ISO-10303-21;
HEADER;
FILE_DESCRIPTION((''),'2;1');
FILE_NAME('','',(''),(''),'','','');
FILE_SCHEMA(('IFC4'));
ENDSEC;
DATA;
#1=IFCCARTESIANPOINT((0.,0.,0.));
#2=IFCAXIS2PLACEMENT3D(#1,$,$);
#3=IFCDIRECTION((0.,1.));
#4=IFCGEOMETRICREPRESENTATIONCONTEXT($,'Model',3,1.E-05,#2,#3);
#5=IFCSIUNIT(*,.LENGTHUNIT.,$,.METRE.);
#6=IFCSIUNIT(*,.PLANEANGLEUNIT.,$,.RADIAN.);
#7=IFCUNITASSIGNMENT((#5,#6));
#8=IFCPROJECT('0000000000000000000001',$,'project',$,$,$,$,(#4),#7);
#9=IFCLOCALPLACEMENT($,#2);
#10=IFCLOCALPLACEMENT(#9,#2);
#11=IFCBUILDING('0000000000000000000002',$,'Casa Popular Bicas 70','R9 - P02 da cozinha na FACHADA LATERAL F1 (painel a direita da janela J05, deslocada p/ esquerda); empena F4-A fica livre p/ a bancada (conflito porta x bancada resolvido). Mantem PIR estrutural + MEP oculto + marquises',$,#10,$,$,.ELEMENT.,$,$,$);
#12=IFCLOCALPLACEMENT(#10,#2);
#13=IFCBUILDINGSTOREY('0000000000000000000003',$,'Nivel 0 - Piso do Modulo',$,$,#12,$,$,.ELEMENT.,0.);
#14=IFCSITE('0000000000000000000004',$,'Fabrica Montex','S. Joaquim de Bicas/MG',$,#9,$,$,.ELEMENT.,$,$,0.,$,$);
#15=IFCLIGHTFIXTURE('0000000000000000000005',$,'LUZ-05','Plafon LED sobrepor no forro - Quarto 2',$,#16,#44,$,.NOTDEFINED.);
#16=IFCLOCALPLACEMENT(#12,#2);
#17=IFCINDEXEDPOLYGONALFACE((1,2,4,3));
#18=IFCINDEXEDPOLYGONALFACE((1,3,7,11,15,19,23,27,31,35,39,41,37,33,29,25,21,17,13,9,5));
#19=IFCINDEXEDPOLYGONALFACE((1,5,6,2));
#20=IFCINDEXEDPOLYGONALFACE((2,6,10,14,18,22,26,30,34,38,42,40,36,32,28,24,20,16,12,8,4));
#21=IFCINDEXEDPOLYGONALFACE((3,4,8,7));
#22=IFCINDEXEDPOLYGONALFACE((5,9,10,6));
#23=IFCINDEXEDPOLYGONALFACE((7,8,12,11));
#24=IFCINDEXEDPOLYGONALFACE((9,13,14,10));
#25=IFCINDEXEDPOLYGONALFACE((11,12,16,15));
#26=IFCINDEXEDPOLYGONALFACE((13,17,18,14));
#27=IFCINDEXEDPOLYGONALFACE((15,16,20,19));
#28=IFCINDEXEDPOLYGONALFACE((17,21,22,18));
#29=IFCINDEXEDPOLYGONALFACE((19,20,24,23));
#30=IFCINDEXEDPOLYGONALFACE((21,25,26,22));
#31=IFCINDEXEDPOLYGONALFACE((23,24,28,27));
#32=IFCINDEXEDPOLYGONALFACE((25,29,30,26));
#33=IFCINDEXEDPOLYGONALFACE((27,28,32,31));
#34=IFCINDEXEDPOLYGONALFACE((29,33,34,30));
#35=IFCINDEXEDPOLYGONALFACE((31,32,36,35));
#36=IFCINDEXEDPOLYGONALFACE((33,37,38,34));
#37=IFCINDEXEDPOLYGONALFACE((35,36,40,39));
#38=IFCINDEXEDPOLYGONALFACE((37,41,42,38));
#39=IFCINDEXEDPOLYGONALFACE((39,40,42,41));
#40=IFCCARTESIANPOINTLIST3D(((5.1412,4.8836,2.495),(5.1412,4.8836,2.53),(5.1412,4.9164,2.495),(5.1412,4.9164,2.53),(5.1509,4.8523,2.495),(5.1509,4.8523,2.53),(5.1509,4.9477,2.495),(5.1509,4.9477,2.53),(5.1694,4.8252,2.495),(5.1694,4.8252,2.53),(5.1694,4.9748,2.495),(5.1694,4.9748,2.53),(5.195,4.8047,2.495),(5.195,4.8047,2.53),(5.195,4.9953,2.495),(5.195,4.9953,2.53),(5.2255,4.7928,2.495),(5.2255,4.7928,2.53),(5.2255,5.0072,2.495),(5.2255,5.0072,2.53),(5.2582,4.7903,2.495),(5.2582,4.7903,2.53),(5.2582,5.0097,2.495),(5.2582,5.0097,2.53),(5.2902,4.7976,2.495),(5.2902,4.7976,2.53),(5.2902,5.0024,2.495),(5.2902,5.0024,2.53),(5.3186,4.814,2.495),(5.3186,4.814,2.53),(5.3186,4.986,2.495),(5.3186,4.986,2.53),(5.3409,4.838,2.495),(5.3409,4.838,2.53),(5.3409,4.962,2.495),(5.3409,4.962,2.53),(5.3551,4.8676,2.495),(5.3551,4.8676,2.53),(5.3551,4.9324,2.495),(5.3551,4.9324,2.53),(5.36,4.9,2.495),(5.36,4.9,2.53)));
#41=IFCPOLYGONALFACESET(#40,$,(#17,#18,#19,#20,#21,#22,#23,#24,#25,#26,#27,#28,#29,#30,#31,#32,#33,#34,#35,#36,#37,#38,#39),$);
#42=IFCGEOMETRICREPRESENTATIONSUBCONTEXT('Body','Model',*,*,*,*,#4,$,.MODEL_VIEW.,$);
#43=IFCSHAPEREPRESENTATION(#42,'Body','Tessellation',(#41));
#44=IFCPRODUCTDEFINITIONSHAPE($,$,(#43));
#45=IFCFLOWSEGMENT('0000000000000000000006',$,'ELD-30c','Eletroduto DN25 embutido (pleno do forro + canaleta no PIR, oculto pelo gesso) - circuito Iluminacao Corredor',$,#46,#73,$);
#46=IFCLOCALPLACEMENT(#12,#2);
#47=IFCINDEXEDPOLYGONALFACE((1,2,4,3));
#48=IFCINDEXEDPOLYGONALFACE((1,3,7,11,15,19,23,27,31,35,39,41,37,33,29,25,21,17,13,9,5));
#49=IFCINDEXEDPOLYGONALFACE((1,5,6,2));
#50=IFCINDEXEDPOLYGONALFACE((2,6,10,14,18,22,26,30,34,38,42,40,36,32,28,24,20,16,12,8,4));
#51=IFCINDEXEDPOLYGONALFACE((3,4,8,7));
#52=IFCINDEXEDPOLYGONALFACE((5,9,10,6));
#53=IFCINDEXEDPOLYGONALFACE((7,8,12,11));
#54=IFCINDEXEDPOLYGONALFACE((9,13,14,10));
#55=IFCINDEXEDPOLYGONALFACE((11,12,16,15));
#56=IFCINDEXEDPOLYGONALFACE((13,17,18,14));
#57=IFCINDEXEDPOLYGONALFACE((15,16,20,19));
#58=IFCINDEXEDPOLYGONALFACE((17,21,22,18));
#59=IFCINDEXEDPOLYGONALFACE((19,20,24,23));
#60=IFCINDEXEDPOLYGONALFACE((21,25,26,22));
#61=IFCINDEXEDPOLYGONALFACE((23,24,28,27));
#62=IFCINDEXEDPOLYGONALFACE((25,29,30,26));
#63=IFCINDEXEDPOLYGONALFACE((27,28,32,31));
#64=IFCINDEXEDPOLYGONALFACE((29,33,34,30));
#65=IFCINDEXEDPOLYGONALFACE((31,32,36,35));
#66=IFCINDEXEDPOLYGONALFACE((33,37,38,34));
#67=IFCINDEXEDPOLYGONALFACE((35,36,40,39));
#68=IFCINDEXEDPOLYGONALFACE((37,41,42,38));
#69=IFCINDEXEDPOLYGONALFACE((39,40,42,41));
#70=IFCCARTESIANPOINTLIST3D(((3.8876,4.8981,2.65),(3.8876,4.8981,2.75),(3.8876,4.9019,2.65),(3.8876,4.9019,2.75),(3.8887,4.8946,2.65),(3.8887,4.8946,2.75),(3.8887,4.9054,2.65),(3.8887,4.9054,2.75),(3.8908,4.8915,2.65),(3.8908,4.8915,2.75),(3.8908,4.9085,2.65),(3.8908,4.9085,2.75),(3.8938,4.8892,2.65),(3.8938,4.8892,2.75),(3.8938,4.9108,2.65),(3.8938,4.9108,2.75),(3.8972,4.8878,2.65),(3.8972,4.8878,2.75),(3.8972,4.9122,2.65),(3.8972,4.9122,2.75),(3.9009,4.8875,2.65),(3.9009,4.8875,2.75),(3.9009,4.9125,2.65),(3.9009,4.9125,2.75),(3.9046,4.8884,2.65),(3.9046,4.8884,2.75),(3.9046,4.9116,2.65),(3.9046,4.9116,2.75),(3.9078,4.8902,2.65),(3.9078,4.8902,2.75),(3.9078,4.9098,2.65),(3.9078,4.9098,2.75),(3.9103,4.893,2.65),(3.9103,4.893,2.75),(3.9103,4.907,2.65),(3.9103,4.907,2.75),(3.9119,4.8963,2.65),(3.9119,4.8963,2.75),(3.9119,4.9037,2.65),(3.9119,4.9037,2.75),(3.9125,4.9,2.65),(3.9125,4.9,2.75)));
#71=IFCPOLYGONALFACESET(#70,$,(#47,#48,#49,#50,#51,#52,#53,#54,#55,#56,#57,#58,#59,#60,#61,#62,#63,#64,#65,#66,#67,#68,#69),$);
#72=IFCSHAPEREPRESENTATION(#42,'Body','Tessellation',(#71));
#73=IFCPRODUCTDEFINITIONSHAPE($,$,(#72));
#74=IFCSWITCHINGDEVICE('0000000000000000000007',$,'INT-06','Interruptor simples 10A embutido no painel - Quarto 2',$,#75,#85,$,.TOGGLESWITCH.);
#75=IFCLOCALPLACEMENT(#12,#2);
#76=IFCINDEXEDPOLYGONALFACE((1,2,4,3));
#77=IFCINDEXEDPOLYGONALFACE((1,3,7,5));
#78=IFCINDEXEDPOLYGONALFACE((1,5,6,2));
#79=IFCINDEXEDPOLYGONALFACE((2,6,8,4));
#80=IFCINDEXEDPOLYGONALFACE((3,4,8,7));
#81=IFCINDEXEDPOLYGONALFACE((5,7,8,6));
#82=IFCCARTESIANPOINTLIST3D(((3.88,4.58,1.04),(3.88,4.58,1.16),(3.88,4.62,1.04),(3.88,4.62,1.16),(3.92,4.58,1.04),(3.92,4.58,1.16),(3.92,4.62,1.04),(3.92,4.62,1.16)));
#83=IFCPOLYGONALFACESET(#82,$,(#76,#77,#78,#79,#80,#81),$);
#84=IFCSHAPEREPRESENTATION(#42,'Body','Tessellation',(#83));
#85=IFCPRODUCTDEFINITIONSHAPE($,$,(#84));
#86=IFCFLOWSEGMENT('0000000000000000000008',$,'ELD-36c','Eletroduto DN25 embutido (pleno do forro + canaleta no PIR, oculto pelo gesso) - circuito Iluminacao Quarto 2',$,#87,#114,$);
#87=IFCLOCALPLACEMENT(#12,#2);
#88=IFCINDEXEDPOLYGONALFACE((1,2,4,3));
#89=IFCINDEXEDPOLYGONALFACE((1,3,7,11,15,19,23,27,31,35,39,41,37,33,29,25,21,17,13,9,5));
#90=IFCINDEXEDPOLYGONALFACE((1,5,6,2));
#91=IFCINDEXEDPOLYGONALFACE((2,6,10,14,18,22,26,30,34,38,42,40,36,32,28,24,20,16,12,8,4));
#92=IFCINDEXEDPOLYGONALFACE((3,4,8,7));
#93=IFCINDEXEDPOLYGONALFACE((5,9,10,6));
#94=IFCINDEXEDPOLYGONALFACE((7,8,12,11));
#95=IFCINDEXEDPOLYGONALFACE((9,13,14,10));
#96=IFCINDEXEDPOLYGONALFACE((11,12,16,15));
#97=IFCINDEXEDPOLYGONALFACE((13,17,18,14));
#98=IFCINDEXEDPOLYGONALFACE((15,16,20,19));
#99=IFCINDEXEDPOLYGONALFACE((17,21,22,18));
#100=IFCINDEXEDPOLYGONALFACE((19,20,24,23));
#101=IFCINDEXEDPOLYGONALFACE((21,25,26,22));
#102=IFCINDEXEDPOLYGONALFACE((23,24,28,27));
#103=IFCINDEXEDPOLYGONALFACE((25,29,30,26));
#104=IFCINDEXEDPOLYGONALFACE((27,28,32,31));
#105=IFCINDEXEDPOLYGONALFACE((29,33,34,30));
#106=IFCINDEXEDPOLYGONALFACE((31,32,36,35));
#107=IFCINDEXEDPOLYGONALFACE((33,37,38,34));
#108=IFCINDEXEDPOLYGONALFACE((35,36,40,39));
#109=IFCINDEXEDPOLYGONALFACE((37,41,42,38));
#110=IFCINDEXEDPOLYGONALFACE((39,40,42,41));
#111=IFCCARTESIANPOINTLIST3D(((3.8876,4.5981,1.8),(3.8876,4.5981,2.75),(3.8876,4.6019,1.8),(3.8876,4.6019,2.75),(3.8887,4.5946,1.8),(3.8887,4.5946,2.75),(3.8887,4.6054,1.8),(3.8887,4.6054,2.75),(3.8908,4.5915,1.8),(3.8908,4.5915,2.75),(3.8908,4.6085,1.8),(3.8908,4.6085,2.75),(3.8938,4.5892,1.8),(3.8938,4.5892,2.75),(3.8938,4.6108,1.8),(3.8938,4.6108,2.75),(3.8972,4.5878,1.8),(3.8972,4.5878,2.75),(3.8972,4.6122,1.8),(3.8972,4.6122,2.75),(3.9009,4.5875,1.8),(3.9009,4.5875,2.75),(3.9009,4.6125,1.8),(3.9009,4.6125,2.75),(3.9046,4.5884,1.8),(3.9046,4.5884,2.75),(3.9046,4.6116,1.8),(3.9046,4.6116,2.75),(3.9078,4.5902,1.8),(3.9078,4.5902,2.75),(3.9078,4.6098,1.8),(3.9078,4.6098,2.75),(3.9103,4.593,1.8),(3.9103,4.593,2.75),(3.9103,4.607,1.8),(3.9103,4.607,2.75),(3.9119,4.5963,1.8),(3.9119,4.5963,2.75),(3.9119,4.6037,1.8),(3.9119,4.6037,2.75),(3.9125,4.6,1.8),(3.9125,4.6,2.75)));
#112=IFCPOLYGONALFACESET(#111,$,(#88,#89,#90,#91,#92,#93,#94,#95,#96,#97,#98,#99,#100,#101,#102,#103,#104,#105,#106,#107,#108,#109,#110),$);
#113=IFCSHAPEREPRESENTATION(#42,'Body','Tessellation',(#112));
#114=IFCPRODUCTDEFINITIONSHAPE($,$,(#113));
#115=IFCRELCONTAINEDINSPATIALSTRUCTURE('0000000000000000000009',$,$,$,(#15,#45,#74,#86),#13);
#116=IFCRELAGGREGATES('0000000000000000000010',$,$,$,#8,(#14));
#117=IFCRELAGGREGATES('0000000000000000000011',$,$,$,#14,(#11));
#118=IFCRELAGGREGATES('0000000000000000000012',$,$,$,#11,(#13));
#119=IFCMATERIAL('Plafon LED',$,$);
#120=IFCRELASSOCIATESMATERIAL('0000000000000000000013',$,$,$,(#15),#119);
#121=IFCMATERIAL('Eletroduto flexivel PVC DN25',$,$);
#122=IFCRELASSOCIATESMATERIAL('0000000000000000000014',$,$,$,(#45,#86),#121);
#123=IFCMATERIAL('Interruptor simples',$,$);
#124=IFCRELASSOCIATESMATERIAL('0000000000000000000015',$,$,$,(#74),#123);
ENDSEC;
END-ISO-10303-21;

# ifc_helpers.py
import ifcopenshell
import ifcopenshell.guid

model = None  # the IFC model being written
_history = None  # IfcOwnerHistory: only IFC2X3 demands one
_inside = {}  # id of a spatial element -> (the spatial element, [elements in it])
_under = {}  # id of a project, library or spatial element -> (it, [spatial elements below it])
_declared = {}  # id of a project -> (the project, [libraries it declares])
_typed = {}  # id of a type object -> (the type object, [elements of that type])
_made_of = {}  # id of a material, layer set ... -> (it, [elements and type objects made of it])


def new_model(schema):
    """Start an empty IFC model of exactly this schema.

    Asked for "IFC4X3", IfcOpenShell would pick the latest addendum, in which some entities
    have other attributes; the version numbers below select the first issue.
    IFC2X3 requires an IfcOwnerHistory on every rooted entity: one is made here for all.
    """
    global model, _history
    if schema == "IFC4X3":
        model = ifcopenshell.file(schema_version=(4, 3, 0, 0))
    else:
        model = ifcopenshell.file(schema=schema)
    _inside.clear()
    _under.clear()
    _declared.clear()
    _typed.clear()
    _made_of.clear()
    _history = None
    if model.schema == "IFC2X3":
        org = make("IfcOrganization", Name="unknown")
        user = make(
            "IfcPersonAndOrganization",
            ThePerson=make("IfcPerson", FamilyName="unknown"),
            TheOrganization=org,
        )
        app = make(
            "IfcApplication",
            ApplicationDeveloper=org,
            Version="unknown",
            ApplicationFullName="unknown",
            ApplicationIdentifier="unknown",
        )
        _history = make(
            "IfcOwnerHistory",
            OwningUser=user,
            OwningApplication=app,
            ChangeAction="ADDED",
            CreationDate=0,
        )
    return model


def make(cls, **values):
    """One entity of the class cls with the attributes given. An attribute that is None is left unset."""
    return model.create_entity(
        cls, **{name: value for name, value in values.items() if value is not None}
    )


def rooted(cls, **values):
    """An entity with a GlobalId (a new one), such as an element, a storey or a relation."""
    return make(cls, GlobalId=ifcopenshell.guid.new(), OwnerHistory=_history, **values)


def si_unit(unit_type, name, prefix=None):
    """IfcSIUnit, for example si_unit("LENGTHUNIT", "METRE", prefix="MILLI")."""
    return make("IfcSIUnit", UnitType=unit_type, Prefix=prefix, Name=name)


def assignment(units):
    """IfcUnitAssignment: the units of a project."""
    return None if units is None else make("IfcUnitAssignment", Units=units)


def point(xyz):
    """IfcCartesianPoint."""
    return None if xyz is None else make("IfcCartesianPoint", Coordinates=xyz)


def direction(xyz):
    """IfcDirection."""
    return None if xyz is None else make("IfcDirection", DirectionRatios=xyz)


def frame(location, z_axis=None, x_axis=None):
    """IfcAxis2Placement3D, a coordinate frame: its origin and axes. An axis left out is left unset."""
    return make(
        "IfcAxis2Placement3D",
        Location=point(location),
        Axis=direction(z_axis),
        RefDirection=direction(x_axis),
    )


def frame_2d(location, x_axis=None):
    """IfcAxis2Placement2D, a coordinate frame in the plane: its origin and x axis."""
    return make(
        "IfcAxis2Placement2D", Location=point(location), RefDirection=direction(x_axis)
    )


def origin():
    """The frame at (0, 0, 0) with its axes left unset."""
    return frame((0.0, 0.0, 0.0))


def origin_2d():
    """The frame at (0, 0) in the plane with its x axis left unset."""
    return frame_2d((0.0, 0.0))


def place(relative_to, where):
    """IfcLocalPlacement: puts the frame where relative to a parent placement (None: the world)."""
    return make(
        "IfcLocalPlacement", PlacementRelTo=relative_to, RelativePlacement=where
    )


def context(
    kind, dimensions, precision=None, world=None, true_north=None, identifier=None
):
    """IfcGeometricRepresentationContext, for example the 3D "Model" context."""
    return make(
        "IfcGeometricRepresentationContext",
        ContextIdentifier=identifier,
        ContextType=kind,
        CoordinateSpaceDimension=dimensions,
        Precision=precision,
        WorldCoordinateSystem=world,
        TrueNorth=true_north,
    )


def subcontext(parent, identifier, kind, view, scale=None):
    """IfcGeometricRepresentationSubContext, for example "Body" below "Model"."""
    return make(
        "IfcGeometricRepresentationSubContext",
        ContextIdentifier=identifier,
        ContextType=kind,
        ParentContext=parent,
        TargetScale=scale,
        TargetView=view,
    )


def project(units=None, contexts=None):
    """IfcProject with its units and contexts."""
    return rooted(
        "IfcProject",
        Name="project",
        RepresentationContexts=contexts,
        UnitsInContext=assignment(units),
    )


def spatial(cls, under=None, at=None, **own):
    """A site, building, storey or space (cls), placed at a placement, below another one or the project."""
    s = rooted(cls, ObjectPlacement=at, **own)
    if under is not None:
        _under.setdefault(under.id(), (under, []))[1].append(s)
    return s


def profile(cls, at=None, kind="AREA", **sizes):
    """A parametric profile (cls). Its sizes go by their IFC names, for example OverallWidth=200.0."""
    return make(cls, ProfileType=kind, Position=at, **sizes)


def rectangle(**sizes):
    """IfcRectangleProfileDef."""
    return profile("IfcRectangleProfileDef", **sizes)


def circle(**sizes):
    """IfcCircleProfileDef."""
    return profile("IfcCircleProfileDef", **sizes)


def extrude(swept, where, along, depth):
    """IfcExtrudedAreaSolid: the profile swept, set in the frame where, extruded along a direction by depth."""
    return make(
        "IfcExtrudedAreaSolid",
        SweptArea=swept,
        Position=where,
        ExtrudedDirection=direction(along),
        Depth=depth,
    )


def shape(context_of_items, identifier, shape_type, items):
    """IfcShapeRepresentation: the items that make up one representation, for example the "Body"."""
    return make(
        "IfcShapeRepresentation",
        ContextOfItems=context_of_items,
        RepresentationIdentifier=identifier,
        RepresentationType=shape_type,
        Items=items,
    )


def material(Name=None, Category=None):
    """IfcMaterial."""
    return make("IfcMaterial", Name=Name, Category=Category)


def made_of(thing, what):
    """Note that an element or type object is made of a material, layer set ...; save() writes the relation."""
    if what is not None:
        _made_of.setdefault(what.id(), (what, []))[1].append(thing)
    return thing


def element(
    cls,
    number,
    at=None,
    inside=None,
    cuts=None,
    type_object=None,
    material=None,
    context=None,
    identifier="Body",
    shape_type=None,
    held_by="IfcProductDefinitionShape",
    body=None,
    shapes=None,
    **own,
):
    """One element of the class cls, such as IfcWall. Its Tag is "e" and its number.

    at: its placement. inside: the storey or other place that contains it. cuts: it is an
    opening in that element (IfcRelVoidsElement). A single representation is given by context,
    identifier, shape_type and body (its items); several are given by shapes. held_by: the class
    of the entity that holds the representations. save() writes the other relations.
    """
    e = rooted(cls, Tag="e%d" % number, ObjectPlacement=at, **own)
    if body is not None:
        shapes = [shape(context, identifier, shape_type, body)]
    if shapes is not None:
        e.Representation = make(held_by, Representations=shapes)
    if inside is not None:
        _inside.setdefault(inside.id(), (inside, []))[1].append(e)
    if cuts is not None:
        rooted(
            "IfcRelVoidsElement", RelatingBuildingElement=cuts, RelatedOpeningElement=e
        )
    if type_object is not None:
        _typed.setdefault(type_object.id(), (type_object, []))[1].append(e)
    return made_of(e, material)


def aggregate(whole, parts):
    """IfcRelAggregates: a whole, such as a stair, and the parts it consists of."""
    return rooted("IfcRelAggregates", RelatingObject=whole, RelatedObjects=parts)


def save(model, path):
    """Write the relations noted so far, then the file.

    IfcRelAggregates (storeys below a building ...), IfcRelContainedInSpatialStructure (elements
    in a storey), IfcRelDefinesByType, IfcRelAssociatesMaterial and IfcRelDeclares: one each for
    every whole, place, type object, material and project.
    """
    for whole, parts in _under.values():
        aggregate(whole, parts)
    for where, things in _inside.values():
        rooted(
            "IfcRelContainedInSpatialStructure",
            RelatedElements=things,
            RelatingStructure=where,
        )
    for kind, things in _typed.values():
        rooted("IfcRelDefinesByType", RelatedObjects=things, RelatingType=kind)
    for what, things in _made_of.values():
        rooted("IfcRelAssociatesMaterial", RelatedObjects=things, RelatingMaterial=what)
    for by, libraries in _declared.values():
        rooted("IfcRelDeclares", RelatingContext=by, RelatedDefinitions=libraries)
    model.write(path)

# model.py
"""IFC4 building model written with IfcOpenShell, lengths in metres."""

from ifc_helpers import new_model, si_unit, direction, frame, frame_2d, origin, origin_2d, place, context, subcontext, project, spatial, rectangle, circle, extrude, material, element, save


model = new_model("IFC4")

# Units and contexts
model_context = context("Model", 3, precision=1e-05, world=origin(), true_north=direction((0.0, 1.0)))
body_context = subcontext(model_context, "Body", "Model", "MODEL_VIEW")
ifc_project = project(units=[si_unit("LENGTHUNIT", "METRE"), si_unit("PLANEANGLEUNIT", "RADIAN")], contexts=[model_context])

# Site, building, storey
site_placement = place(None, origin())
site = spatial("IfcSite", under=ifc_project, at=site_placement, Name="Fabrica Montex", Description="S. Joaquim de Bicas/MG", CompositionType="ELEMENT", RefElevation=0.0)
building_placement = place(site_placement, origin())
building = spatial("IfcBuilding", under=site, at=building_placement, Name="Casa Popular Bicas 70", Description="R9 - P02 da cozinha na FACHADA LATERAL F1 (painel a direita da janela J05, deslocada p/ esquerda); empena F4-A fica livre p/ a bancada (conflito porta x bancada resolvido). Mantem PIR estrutural + MEP oculto + marquises", CompositionType="ELEMENT")
storey_placement = place(building_placement, origin())
storey = spatial("IfcBuildingStorey", under=building, at=storey_placement, Name="Nivel 0 - Piso do Modulo", CompositionType="ELEMENT", Elevation=0.0)

# Shared definitions
ifc_material_1 = material(Name="Eletroduto flexivel PVC DN25")

# Light fixture
ifc_material_2 = material(Name="Plafon LED")
light_fixture_placement = place(storey_placement, frame((5.25, 4.9, 2.495)))
element("IfcLightFixture", 1, at=light_fixture_placement, inside=storey, material=ifc_material_2, Name="LUZ-05", Description="Plafon LED sobrepor no forro - Quarto 2", PredefinedType="NOTDEFINED", context=body_context, shape_type="SweptSolid", body=[
    extrude(circle(Radius=0.11, at=origin_2d()), origin(), (0.0, 0.0, 1.0), 0.035),
])

# Flow segment
for number, where, z_axis, x_axis, name in (
    (2, (3.9, 4.9, 2.75), (0.0, 0.0, -1.0), (1.0, 0.0, 0.0), "ELD-30c"),
):
    element("IfcFlowSegment", number, at=place(storey_placement, frame(where, z_axis=z_axis, x_axis=x_axis)), inside=storey, material=ifc_material_1, Name=name, Description="Eletroduto DN25 embutido (pleno do forro + canaleta no PIR, oculto pelo gesso) - circuito Iluminacao Corredor", context=body_context, shape_type="SweptSolid", body=[
        extrude(circle(Radius=0.0125, at=origin_2d()), origin(), (0.0, 0.0, 1.0), 0.1),
    ])

# Switching device
ifc_material_3 = material(Name="Interruptor simples")
switching_device_placement = place(storey_placement, frame((3.88, 4.58, 1.04)))
element("IfcSwitchingDevice", 3, at=switching_device_placement, inside=storey, material=ifc_material_3, Name="INT-06", Description="Interruptor simples 10A embutido no painel - Quarto 2", PredefinedType="TOGGLESWITCH", context=body_context, shape_type="SweptSolid", body=[
    extrude(rectangle(XDim=0.04, YDim=0.04, at=frame_2d((0.02, 0.02))), origin(), (0.0, 0.0, 1.0), 0.12),
])

# Flow segment
flow_segment_1_placement = place(storey_placement, frame((3.9, 4.6, 2.75), z_axis=(0.0, 0.0, -1.0), x_axis=(1.0, 0.0, 0.0)))
element("IfcFlowSegment", 4, at=flow_segment_1_placement, inside=storey, material=ifc_material_1, Name="ELD-36c", Description="Eletroduto DN25 embutido (pleno do forro + canaleta no PIR, oculto pelo gesso) - circuito Iluminacao Quarto 2", context=body_context, shape_type="SweptSolid", body=[
    extrude(circle(Radius=0.0125, at=origin_2d()), origin(), (0.0, 0.0, 1.0), 0.95),
])

save(model, "model.ifc")
